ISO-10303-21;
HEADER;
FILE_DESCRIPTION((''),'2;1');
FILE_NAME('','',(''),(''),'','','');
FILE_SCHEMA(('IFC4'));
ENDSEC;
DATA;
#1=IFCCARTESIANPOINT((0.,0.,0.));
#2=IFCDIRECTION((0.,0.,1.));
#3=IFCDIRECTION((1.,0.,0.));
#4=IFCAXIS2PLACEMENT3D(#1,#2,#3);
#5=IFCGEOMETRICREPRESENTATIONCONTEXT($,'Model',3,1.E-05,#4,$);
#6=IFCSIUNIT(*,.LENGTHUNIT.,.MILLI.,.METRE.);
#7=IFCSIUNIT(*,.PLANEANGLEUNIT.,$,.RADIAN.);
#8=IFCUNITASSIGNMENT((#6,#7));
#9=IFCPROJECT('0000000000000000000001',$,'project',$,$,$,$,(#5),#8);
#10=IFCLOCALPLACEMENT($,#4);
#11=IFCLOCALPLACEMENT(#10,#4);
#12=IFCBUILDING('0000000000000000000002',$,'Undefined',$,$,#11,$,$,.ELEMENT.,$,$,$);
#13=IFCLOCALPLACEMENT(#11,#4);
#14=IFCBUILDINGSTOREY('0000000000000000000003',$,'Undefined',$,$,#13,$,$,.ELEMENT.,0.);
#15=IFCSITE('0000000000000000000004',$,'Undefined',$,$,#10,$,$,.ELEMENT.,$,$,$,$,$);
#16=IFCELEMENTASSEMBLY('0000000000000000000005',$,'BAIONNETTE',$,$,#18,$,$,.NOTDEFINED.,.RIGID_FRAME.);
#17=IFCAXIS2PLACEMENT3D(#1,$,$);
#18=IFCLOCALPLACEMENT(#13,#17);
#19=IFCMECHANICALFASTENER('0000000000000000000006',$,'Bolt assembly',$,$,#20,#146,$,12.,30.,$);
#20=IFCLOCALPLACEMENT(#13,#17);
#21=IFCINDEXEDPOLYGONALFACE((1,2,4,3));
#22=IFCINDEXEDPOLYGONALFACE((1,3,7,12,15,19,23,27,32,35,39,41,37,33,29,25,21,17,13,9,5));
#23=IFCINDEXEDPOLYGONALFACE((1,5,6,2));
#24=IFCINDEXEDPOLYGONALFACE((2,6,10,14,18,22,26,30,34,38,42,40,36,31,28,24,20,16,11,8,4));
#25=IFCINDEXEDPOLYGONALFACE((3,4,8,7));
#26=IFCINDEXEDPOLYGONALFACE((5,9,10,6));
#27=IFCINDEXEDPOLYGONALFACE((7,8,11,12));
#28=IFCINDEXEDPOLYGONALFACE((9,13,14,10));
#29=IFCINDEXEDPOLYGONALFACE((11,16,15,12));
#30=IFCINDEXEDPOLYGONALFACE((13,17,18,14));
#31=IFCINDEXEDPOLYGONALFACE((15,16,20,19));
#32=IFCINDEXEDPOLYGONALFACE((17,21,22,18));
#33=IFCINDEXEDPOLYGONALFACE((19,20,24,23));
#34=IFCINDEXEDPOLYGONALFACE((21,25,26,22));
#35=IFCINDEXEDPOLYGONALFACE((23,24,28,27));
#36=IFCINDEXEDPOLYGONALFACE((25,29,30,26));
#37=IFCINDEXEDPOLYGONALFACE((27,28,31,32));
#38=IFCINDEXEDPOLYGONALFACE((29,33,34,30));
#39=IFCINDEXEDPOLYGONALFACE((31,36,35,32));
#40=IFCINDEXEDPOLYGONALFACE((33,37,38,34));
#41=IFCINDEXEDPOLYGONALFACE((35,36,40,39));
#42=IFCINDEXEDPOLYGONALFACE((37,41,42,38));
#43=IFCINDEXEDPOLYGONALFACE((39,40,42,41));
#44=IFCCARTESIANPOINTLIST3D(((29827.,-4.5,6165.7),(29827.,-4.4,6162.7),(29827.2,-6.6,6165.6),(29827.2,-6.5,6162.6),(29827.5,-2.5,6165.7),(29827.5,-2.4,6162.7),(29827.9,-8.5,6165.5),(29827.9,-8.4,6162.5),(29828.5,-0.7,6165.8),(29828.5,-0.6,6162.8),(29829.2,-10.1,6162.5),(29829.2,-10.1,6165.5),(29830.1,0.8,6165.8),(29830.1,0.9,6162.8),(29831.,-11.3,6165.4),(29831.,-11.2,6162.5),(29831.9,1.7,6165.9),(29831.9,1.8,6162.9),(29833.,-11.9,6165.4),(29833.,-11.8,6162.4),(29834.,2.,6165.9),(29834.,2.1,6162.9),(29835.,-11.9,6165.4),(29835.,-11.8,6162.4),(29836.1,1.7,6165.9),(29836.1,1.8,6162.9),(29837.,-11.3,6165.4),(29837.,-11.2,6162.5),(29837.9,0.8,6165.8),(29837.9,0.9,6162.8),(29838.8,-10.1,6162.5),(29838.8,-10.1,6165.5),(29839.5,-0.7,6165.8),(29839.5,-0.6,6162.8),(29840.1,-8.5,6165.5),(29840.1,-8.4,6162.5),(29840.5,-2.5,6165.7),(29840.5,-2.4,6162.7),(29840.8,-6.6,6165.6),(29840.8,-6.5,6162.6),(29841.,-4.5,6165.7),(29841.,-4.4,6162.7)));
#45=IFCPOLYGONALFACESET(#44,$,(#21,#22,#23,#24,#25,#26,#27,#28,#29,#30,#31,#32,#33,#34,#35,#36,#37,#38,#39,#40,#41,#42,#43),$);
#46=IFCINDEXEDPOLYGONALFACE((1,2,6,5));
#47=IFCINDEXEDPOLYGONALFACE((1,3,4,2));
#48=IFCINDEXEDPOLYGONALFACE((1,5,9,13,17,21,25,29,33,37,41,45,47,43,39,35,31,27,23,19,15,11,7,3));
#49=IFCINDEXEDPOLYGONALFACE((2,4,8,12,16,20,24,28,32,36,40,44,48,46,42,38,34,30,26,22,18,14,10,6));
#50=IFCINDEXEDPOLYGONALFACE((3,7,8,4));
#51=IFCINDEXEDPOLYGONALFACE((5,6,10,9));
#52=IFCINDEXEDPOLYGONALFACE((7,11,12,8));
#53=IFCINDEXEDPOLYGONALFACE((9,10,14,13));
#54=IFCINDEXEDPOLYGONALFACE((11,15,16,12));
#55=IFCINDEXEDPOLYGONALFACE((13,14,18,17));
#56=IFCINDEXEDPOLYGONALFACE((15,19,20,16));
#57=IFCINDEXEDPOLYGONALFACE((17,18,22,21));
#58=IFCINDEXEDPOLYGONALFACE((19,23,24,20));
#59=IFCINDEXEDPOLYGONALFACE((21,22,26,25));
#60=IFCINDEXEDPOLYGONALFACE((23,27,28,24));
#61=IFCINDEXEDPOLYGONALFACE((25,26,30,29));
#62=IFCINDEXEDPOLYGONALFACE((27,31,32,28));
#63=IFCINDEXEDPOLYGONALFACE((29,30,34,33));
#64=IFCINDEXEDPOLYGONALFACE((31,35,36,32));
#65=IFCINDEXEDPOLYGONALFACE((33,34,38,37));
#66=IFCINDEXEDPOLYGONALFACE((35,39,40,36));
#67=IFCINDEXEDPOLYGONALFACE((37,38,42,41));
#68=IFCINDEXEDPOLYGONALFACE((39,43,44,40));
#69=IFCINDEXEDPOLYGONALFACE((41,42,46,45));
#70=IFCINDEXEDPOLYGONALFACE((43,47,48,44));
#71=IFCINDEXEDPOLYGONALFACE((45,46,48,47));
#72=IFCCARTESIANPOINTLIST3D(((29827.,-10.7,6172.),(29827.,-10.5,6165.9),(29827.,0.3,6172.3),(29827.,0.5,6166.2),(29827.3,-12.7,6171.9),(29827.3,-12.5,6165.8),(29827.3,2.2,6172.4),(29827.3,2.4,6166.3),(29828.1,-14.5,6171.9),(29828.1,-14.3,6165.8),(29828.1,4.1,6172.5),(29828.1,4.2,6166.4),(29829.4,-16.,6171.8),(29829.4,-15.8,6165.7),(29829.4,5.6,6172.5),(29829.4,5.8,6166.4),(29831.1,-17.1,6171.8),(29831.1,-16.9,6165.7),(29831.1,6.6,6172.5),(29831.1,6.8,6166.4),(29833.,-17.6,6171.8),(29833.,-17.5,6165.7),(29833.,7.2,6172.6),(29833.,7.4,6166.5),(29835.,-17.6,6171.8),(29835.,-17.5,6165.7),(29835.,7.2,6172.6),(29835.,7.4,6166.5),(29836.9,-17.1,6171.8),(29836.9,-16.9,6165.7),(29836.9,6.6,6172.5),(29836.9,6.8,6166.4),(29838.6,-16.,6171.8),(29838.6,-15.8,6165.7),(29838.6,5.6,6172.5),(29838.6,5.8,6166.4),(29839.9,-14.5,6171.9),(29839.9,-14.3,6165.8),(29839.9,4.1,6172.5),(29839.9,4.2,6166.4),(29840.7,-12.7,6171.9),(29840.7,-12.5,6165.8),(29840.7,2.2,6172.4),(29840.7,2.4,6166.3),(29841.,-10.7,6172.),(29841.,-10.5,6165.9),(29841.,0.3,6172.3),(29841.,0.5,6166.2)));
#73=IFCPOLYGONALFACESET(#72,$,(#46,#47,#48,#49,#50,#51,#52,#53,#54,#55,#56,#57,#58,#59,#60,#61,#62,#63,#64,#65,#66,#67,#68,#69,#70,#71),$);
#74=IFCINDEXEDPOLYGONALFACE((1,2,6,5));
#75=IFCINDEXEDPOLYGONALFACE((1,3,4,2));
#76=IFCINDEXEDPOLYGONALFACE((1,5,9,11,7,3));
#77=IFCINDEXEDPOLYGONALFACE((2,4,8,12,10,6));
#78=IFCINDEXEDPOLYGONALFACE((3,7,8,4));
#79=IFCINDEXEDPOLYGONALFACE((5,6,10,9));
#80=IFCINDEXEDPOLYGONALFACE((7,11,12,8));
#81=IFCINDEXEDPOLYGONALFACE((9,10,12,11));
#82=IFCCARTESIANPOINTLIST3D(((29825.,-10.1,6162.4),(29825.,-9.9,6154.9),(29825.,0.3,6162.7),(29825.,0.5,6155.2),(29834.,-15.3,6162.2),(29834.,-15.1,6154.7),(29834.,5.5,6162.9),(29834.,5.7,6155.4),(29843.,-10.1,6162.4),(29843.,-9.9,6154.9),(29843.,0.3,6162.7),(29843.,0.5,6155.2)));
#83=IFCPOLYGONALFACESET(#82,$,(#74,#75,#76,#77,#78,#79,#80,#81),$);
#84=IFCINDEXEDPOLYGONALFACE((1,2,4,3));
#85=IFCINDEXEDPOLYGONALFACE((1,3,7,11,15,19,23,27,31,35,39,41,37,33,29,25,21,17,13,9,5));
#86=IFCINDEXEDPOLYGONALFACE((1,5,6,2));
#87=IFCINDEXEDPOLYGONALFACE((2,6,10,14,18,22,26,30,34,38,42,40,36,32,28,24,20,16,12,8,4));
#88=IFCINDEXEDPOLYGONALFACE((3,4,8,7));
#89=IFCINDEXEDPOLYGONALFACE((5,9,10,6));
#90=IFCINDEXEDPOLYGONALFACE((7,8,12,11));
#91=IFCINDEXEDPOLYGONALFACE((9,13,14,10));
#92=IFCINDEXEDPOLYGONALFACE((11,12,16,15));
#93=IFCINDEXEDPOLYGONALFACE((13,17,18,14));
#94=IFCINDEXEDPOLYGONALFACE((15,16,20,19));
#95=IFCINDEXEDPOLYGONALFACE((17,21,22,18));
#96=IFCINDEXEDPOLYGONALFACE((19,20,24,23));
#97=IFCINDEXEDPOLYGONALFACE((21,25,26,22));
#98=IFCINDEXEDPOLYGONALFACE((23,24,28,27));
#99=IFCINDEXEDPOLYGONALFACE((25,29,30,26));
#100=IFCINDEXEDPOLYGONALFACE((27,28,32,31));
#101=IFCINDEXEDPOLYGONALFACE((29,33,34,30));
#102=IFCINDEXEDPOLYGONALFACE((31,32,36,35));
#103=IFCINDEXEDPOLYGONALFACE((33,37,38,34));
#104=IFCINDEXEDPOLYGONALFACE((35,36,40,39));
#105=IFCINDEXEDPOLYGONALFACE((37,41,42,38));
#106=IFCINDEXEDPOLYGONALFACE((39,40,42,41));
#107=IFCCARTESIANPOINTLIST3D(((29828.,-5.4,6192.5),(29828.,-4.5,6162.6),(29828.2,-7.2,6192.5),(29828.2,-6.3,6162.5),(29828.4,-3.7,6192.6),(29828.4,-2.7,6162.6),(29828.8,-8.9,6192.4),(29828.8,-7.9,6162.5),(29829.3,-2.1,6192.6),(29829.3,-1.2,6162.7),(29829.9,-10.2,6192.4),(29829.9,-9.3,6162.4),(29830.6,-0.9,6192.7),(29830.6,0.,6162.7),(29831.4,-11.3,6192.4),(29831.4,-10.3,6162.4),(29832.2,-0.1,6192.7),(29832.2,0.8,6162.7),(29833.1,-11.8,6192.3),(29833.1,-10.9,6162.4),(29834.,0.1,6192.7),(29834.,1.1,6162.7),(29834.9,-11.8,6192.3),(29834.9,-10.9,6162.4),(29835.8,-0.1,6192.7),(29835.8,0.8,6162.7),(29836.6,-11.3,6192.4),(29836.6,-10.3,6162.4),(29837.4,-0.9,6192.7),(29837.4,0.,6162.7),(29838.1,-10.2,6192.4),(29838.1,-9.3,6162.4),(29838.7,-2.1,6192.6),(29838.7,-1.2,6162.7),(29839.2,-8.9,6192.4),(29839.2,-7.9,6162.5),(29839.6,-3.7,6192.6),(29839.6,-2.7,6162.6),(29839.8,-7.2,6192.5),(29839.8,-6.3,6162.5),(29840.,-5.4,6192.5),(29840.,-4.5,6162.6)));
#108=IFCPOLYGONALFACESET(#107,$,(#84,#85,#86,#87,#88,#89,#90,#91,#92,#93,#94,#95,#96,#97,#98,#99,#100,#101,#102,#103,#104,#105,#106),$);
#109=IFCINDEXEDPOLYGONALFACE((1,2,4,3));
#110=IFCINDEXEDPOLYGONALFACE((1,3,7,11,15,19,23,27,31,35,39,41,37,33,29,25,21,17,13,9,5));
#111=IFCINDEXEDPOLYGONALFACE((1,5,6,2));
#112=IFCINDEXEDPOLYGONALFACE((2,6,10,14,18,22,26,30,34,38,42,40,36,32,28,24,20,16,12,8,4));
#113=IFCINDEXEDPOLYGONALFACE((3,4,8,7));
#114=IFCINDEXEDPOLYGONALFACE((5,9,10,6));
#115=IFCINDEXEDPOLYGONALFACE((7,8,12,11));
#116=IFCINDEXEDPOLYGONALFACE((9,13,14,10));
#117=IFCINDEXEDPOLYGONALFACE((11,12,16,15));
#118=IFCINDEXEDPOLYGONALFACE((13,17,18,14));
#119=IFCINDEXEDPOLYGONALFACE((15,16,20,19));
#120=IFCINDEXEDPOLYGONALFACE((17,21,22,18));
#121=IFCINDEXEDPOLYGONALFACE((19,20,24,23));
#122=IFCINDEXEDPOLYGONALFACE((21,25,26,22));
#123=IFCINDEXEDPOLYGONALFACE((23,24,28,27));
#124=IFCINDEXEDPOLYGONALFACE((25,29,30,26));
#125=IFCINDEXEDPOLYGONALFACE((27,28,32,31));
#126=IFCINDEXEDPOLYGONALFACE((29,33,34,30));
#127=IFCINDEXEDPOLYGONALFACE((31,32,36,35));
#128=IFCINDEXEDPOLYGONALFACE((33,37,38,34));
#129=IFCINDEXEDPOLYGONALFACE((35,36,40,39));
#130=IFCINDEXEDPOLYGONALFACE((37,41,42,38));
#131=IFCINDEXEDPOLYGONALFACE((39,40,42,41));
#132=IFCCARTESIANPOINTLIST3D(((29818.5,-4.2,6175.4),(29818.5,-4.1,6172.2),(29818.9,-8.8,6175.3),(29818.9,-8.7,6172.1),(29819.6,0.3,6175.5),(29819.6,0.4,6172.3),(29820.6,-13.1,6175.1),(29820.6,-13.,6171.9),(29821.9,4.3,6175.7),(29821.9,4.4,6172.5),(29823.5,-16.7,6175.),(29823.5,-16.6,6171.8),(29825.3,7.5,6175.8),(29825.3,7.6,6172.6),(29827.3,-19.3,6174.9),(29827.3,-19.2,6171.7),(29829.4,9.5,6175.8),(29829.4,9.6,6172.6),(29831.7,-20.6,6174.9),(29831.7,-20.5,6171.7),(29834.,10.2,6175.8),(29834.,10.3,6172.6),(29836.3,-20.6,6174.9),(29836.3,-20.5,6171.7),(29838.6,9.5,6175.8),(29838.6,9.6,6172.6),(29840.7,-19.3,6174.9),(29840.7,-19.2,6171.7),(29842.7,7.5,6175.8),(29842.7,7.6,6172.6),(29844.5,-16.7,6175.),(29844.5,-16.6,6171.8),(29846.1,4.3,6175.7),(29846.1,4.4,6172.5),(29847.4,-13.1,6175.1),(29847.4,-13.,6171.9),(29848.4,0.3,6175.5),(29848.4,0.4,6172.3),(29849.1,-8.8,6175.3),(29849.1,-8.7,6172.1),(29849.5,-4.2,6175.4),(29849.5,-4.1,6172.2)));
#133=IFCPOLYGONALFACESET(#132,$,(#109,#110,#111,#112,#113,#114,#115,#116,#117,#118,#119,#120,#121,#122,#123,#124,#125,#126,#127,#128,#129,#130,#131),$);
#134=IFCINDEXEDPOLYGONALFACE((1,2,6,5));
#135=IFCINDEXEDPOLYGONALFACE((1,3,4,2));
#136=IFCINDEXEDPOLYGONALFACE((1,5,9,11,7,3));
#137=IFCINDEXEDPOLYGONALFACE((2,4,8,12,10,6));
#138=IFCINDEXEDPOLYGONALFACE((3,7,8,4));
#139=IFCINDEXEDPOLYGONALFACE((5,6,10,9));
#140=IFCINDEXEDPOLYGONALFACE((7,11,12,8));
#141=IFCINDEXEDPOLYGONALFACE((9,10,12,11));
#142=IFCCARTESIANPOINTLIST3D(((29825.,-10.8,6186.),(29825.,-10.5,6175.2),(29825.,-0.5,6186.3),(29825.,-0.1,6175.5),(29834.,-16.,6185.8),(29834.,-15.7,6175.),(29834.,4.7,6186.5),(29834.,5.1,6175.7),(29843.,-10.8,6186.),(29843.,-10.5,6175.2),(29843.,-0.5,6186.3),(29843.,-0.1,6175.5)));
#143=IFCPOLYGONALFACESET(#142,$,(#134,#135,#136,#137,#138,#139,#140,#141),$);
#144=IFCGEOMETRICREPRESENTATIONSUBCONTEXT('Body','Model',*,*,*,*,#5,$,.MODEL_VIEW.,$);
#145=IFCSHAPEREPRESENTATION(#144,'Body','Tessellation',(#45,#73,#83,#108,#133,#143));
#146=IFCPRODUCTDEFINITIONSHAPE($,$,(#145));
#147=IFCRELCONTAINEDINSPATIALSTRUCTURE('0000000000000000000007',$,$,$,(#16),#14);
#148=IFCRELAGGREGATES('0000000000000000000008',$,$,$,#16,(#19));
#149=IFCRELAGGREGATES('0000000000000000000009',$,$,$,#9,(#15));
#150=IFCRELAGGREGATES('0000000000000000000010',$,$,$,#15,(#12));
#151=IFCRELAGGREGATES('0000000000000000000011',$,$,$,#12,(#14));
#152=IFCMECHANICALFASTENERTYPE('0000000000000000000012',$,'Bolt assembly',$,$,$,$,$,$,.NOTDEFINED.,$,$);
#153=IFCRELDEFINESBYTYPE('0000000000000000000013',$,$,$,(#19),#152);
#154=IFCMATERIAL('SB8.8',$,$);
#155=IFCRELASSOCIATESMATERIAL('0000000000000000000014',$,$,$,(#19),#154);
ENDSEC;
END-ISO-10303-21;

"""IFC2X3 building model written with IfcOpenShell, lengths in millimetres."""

from ifc_helpers import new_model, si_unit, frame, frame_2d, origin_with_axes, origin_2d_with_axis, place, context, subcontext, project, spatial, polyline, circle_curve, parameter, trimmed, segment, composite_curve, circle, outline, extrude, source, transform, mapped, material, type_object, element, aggregate, save


model = new_model("IFC2X3")

# Units and contexts
model_context = context("Model", 3, precision=1e-05, world=origin_with_axes())
body_context = subcontext(model_context, "Body", "Model", "MODEL_VIEW")
ifc_project = project(units=[si_unit("LENGTHUNIT", "METRE", prefix="MILLI"), si_unit("PLANEANGLEUNIT", "RADIAN")], contexts=[model_context])

# Site, building, storey
site_placement = place(None, origin_with_axes())
site = spatial("IfcSite", under=ifc_project, at=site_placement, Name="Undefined", CompositionType="ELEMENT")
building_placement = place(site_placement, origin_with_axes())
building = spatial("IfcBuilding", under=site, at=building_placement, Name="Undefined", CompositionType="ELEMENT")
storey_placement = place(building_placement, origin_with_axes())
storey = spatial("IfcBuildingStorey", under=building, at=storey_placement, Name="Undefined", CompositionType="ELEMENT", Elevation=0.0)

# Element assembly
assembly_1_placement = place(storey_placement, origin_with_axes())
assembly_1 = element("IfcElementAssembly", 1, at=assembly_1_placement, inside=storey, Name="BAIONNETTE", AssemblyPlace="NOTDEFINED", PredefinedType="RIGID_FRAME")

# Shared definitions
ifc_material_1 = material(Name="SB8.8")
mechanical_fastener_type = type_object("IfcMechanicalFastenerType", Name="Bolt assembly")

# Mechanical fastener
shared_shape_1 = source(origin_with_axes(), body_context, "Body", "SweptSolid", [
    extrude(circle(Radius=7.0, at=origin_2d_with_axis()), frame((0.0, -2.9, 0.0), z_axis=(0.0, 1.0, 0.0), x_axis=(1.0, 0.0, 0.0)), (0.0, 0.0, 1.0), 3.0),
    extrude(outline(composite_curve([segment(polyline([(-5.5, 7.0), (5.5, 7.0)]), True, "CONTINUOUS"), segment(trimmed(circle_curve(frame_2d((5.5, 0.0), x_axis=(0.0, 1.0)), 7.0), [parameter(0.0)], [parameter(3.141593)], False, "PARAMETER"), True, "CONTINUOUS"), segment(polyline([(5.5, -7.0), (-5.5, -7.0)]), True, "CONTINUOUS"), segment(trimmed(circle_curve(frame_2d((-5.5, 0.0), x_axis=(0.0, -1.0)), 7.0), [parameter(0.0)], [parameter(3.141593)], False, "PARAMETER"), True, "DISCONTINUOUS")], self_intersect=False)), frame((0.0, 0.5, 0.0), z_axis=(0.0, 1.0, 0.0), x_axis=(1.0, 0.0, 0.0)), (0.0, 0.0, 1.0), 6.1),
    extrude(outline(polyline([(10.4, 0.0), (5.2, 9.0), (-5.2, 9.0), (-10.4, 0.0), (-5.2, -9.0), (5.2, -9.0), (10.4, 0.0)])), frame((0.0, -10.5, 0.0), z_axis=(0.0, 1.0, 0.0), x_axis=(1.0, 0.0, 0.0)), (0.0, 0.0, 1.0), 7.5),
    extrude(circle(Radius=6.0, at=origin_2d_with_axis()), frame((0.0, -3.0, 0.0), z_axis=(0.0, 1.0, 0.0), x_axis=(1.0, 0.0, 0.0)), (0.0, 0.0, 1.0), 30.0),
    extrude(circle(Radius=15.5, at=origin_2d_with_axis()), frame((0.0, 6.6, 0.0), z_axis=(0.0, 1.0, 0.0), x_axis=(1.0, 0.0, 0.0)), (0.0, 0.0, 1.0), 3.2),
    extrude(outline(polyline([(10.4, 0.0), (5.2, 9.0), (-5.2, 9.0), (-10.4, 0.0), (-5.2, -9.0), (5.2, -9.0), (10.4, 0.0)])), frame((0.0, 9.8, 0.0), z_axis=(0.0, 1.0, 0.0), x_axis=(1.0, 0.0, 0.0)), (0.0, 0.0, 1.0), 10.8),
])
mechanical_fastener_1_placement = place(assembly_1_placement, frame((29834.0, -5.0, 6165.5), z_axis=(1.0, 0.0, 0.0), x_axis=(0.0, 0.99952, 0.030985)))
mechanical_fastener_1 = element("IfcMechanicalFastener", 2, at=mechanical_fastener_1_placement, type_object=mechanical_fastener_type, material=ifc_material_1, Name="Bolt assembly", NominalDiameter=12.0, NominalLength=30.0, context=body_context, shape_type="MappedRepresentation", body=[
    mapped(shared_shape_1, transform((0.0, 0.0, 0.0))),
])
aggregate(assembly_1, [mechanical_fastener_1])

save(model, "model.ifc")
